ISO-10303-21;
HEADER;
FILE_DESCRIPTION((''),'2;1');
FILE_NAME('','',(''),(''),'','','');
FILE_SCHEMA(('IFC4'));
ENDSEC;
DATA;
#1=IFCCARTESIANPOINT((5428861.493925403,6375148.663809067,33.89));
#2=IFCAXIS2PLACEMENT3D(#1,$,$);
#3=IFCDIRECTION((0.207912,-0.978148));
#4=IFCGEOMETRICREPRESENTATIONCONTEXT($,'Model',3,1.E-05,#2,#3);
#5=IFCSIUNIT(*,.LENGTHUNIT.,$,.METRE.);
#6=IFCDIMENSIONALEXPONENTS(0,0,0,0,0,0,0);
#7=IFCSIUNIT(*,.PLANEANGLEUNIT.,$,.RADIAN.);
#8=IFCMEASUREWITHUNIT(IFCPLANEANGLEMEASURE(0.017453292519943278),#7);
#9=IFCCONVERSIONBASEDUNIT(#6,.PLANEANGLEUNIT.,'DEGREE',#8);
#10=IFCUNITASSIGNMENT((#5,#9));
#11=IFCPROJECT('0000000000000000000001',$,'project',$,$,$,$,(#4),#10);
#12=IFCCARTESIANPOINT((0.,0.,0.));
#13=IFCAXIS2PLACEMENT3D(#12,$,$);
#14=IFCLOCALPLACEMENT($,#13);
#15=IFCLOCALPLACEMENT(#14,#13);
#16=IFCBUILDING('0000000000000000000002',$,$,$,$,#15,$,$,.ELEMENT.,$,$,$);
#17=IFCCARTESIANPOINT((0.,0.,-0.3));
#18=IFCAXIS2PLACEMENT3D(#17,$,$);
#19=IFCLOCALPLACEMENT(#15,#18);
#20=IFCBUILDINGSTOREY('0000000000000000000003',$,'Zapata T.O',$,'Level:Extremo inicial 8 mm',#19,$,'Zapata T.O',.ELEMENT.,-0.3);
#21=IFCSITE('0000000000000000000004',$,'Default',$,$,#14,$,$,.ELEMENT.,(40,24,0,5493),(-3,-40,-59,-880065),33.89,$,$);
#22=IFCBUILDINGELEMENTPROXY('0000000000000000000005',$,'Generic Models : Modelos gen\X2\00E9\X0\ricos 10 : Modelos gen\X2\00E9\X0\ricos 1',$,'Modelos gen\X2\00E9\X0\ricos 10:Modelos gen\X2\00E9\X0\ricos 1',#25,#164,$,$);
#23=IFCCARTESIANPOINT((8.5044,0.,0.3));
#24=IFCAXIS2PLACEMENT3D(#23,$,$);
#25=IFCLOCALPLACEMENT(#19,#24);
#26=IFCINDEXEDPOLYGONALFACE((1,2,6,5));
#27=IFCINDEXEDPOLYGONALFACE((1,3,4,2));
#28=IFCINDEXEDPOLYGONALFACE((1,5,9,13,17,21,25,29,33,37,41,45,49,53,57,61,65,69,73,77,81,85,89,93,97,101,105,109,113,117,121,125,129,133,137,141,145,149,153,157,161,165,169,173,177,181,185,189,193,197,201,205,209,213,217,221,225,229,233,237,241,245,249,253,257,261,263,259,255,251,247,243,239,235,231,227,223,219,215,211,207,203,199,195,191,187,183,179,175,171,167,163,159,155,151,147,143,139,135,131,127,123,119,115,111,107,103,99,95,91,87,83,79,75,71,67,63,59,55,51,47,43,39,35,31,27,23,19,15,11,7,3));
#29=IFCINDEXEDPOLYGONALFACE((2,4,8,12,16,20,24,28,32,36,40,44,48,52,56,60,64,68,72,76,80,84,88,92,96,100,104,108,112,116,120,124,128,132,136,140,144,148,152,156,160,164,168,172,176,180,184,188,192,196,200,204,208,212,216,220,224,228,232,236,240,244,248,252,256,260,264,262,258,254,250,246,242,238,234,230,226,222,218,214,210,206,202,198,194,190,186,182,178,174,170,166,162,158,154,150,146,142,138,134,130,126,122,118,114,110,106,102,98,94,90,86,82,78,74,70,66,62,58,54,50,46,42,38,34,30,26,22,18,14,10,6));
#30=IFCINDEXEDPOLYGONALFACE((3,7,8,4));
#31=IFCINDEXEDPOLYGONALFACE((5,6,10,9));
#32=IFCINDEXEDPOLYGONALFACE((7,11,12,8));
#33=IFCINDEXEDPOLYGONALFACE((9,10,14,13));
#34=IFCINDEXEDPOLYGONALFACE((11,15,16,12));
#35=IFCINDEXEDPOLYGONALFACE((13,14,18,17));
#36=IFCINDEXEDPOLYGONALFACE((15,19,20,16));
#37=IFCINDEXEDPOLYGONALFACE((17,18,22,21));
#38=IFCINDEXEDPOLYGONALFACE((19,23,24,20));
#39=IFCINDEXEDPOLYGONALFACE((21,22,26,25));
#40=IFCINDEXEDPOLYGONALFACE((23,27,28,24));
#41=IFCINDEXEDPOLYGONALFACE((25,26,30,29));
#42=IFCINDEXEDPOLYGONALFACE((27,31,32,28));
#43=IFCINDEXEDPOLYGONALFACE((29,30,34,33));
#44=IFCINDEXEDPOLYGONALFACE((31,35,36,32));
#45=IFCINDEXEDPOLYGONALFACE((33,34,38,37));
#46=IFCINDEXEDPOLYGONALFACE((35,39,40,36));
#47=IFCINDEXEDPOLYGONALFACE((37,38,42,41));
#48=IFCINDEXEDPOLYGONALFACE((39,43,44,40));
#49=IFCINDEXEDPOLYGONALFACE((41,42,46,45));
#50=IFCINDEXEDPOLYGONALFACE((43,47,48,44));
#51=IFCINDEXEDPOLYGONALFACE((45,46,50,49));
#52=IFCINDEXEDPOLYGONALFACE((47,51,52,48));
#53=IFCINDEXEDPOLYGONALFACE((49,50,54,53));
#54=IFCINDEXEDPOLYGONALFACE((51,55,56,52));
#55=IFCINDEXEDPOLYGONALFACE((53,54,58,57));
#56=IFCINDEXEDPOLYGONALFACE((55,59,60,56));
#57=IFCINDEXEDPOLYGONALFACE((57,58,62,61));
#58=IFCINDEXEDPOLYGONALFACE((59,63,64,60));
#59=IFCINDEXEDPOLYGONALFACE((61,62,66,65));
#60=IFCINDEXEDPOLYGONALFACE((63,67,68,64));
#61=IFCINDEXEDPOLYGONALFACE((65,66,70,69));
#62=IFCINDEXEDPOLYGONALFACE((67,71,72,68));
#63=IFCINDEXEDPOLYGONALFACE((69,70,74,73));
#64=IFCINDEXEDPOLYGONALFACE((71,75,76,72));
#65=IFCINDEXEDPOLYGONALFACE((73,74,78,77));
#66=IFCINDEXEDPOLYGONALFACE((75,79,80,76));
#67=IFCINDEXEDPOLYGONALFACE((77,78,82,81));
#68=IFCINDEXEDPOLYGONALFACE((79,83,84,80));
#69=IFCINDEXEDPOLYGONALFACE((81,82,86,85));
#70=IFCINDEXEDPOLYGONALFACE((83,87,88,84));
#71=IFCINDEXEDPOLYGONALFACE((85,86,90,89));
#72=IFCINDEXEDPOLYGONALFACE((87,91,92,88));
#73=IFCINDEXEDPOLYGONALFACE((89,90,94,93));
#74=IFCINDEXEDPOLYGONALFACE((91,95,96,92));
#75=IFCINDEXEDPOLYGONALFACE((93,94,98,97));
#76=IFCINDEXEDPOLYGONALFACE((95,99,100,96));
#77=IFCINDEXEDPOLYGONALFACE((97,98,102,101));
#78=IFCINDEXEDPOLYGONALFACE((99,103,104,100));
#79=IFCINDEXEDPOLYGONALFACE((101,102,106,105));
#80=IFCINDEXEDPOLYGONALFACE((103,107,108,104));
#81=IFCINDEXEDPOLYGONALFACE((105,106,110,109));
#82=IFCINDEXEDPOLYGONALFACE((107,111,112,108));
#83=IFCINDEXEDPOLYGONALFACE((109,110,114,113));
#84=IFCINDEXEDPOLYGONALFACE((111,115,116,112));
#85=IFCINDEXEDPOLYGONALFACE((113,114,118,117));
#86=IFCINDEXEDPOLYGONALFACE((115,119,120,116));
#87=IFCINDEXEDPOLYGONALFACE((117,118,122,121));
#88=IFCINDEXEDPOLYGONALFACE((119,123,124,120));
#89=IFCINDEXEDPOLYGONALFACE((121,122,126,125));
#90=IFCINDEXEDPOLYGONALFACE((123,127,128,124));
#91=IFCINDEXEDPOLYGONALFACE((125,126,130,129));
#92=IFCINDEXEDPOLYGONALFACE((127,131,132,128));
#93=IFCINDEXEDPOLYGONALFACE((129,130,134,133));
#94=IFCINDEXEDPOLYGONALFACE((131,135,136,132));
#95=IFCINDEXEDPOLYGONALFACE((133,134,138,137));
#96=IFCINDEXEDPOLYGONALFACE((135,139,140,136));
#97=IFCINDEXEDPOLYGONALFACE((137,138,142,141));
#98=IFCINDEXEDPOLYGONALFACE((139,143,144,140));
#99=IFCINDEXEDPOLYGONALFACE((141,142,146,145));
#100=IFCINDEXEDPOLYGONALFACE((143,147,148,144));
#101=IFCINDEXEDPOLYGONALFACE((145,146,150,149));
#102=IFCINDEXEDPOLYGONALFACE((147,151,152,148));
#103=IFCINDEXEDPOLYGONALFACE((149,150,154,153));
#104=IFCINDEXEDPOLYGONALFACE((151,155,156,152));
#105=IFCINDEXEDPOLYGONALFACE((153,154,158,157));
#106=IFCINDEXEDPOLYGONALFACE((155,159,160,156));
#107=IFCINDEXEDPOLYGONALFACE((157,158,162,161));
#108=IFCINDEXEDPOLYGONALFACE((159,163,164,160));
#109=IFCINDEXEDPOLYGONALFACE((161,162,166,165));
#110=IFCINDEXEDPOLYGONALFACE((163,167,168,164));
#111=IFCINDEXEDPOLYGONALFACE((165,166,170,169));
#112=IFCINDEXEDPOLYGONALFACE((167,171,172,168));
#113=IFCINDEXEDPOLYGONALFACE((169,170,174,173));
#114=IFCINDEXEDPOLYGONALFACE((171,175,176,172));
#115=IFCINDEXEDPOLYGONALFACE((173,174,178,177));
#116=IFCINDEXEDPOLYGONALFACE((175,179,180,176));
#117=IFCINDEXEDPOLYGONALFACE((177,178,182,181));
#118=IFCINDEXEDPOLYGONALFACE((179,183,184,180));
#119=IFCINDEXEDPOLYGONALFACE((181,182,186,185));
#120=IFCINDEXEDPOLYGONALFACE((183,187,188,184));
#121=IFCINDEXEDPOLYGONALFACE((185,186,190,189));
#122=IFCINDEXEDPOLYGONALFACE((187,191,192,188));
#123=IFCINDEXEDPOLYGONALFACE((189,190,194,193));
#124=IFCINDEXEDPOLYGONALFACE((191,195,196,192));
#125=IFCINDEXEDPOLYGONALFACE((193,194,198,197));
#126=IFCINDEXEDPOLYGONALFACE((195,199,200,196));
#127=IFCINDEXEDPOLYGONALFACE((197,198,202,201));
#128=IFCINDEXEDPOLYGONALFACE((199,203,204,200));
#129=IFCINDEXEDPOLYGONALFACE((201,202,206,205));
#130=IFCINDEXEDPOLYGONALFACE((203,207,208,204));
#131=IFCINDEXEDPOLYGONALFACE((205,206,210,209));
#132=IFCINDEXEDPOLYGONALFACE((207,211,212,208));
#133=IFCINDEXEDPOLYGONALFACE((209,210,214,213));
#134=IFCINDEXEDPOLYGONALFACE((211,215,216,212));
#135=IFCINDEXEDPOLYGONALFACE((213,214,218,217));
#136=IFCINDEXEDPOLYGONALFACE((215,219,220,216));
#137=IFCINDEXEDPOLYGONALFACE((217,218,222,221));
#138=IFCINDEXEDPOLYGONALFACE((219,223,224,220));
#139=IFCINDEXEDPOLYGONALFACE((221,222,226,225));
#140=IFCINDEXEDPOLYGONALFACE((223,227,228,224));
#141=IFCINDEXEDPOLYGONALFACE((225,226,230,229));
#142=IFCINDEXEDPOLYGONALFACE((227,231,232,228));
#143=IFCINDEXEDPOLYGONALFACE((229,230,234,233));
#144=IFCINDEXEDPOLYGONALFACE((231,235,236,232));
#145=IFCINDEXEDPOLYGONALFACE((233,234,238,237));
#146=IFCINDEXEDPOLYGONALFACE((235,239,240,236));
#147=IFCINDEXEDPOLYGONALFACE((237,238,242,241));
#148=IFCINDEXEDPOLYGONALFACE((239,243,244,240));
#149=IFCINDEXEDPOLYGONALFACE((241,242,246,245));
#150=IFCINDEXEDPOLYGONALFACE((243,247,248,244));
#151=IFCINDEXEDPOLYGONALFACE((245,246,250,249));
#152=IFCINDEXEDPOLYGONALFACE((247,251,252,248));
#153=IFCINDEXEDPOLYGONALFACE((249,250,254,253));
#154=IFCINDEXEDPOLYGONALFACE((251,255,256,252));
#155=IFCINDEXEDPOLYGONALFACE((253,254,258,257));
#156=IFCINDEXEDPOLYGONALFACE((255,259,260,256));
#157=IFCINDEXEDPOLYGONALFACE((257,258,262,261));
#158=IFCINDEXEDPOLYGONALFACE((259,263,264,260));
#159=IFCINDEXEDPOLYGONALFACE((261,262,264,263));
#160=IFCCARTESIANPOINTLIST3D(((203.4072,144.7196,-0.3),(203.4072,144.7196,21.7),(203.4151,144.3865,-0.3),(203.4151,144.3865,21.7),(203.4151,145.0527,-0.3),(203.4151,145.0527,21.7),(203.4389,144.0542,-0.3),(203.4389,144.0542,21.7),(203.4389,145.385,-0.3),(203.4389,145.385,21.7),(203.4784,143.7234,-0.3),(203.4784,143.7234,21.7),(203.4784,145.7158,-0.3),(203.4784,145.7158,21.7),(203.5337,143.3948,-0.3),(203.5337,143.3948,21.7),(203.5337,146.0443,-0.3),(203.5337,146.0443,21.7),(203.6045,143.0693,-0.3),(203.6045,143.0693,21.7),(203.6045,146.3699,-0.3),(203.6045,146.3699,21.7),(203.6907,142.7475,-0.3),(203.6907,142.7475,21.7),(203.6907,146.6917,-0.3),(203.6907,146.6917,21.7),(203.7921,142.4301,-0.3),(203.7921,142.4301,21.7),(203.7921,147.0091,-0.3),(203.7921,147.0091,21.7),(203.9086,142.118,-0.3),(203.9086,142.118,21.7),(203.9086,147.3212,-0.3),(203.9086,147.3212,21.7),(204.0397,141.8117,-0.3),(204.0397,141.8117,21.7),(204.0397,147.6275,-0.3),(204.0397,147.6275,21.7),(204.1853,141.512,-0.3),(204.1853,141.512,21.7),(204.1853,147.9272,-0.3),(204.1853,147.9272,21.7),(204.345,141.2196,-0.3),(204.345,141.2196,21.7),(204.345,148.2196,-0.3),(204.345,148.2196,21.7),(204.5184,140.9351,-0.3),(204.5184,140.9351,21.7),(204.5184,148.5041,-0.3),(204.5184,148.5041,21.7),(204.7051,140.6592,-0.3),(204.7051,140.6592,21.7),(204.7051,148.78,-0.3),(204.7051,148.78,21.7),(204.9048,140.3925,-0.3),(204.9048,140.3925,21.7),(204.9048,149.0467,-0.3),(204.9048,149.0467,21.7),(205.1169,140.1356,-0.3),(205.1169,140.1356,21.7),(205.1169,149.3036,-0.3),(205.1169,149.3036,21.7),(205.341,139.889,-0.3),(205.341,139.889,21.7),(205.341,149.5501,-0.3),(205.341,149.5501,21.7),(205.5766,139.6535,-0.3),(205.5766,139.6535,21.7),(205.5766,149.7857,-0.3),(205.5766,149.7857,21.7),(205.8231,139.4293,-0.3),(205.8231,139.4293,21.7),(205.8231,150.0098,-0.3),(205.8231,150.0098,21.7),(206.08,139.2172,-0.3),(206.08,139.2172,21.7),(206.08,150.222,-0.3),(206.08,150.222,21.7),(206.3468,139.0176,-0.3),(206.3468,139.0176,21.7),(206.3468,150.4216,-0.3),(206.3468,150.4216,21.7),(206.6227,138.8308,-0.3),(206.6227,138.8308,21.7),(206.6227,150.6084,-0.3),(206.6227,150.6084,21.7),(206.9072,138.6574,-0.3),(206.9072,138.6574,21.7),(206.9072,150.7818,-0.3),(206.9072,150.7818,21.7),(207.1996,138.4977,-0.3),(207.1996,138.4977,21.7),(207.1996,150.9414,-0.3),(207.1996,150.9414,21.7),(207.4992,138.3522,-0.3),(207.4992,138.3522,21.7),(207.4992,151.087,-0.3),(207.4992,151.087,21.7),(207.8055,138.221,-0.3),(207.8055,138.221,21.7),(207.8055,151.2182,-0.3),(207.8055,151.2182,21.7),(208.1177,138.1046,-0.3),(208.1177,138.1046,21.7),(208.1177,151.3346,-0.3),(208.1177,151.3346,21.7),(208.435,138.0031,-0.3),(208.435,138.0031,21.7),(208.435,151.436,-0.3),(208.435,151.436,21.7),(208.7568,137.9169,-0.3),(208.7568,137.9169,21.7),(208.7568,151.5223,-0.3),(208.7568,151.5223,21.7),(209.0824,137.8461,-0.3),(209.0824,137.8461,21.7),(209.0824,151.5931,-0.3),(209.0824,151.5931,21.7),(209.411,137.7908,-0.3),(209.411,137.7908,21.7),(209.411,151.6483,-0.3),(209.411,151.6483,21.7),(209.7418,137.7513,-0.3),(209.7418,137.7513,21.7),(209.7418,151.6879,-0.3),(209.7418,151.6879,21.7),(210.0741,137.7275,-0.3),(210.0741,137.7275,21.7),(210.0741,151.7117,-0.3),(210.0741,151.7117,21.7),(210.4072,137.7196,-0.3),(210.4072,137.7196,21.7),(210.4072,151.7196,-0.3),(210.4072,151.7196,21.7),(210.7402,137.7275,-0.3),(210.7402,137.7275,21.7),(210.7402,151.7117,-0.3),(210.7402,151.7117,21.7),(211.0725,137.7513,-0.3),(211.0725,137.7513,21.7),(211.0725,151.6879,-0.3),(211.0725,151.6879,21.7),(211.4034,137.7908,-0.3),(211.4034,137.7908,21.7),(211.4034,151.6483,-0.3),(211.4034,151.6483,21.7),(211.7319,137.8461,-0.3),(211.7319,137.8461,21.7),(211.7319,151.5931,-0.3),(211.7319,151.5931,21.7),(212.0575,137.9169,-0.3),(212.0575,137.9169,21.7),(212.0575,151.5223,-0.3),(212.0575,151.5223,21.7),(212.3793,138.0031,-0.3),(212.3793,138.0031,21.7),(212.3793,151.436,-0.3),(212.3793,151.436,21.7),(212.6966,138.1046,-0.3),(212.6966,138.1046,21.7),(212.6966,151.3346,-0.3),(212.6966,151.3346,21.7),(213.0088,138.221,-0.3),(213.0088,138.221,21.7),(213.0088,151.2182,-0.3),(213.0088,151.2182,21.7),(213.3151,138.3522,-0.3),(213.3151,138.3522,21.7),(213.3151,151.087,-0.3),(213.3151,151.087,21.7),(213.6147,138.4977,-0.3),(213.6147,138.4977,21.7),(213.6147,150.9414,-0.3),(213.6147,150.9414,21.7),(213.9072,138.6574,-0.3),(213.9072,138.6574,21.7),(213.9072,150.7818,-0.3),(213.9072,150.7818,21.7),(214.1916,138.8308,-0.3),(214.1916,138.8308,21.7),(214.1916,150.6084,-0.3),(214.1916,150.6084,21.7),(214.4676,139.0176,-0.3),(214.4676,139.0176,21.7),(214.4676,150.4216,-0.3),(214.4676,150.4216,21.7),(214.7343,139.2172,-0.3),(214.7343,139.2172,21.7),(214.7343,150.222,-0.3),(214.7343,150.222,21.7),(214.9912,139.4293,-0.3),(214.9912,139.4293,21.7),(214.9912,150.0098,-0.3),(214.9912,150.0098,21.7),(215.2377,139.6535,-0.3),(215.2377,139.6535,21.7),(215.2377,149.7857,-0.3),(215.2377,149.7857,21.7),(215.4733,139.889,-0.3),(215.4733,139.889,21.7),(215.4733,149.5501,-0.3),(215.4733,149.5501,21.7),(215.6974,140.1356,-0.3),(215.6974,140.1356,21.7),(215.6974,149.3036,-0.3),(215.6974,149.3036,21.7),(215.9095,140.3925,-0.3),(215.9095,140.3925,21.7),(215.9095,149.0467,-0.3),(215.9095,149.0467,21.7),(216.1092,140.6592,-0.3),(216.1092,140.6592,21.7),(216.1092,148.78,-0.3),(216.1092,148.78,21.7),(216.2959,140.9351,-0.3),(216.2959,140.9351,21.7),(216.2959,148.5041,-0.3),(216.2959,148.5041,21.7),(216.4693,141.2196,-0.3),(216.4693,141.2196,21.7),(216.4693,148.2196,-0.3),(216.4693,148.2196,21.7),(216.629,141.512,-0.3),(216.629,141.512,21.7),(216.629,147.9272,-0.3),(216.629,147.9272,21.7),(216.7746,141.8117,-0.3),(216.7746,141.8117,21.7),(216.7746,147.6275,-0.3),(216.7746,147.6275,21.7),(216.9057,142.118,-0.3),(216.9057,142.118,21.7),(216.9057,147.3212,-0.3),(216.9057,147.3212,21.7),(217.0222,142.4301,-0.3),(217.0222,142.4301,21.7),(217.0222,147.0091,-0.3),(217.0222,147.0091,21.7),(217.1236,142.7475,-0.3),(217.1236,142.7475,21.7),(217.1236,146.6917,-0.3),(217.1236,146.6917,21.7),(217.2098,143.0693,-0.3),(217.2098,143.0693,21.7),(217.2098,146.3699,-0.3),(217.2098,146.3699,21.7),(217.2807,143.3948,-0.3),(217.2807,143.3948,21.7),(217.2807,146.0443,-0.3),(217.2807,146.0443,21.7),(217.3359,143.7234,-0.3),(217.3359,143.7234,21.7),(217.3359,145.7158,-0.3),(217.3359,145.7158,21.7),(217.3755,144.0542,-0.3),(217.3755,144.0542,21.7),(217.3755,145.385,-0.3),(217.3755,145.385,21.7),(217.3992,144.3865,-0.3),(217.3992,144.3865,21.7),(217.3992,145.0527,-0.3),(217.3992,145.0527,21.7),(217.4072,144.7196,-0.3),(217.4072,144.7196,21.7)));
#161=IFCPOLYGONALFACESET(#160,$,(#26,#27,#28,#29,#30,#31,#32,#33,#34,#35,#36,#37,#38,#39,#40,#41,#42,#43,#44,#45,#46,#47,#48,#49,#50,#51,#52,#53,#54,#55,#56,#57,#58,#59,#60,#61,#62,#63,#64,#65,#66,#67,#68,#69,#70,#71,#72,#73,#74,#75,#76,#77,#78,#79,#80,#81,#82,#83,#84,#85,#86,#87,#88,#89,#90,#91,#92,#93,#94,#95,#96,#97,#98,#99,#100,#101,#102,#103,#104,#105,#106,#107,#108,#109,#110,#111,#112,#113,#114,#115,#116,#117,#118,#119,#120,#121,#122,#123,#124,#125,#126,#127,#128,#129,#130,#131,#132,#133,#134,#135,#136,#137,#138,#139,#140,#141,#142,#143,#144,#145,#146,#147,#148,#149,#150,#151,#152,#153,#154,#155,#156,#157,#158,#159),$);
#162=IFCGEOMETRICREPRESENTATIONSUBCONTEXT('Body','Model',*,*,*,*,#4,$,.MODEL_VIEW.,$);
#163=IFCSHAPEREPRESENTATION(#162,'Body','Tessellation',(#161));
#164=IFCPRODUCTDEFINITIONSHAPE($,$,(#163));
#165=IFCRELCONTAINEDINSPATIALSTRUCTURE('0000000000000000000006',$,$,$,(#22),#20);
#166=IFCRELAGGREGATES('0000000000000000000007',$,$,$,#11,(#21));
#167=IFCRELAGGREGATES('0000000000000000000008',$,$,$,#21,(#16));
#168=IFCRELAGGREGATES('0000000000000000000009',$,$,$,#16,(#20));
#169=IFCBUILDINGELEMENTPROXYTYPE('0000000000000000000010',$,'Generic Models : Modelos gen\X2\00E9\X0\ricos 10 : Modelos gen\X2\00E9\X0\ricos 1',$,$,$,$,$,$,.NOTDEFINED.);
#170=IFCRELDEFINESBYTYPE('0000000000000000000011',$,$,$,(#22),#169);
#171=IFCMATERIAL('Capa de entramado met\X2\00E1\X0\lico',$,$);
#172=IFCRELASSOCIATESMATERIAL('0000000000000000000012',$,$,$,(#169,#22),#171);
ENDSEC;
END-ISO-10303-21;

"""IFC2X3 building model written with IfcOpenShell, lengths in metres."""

from ifc_helpers import new_model, entity, si_unit, converted_unit, direction, frame, frame_2d, origin, place, context, subcontext, project, spatial, circle, extrude, source, transform, mapped, material, type_object, type_shapes, element, save


model = new_model("IFC2X3")

# Units and contexts
model_context = context("Model", 3, precision=1e-05, world=frame((5428861.493925403, 6375148.663809067, 33.89)), true_north=direction((0.207912, -0.978148)))
body_context = subcontext(model_context, "Body", "Model", "MODEL_VIEW")
ifc_project = project(units=[si_unit("LENGTHUNIT", "METRE"), converted_unit("PLANEANGLEUNIT", "DEGREE", entity("IfcPlaneAngleMeasure", 0.017453292519943278), si_unit("PLANEANGLEUNIT", "RADIAN"), dimensions=[0, 0, 0, 0, 0, 0, 0])], contexts=[model_context])

# Site, building, storey
site_placement = place(None, origin())
site = spatial("IfcSite", under=ifc_project, at=site_placement, Name="Default", CompositionType="ELEMENT", RefLatitude=(40, 24, 0, 5493), RefLongitude=(-3, -40, -59, -880065), RefElevation=33.89)
building_placement = place(site_placement, origin())
building = spatial("IfcBuilding", under=site, at=building_placement, CompositionType="ELEMENT")
storey_placement = place(building_placement, frame((0.0, 0.0, -0.3)))
storey = spatial("IfcBuildingStorey", under=building, at=storey_placement, Name="Zapata T.O", ObjectType="Level:Extremo inicial 8 mm", LongName="Zapata T.O", CompositionType="ELEMENT", Elevation=-0.3)

# Building element proxy
ifc_material = material(Name="Capa de entramado metálico")
building_element_proxy_type_1 = type_object("IfcBuildingElementProxyType", Name="Generic Models : Modelos genéricos 10 : Modelos genéricos 1", PredefinedType="NOTDEFINED", material=ifc_material)
shared_shape_1 = source(origin(), body_context, "Body", "SweptSolid", [
    extrude(circle(Radius=7.0, at=frame_2d((0.0, 0.0), x_axis=(1.0, 0.0))), frame((210.4072, 144.7196, -0.3)), (0.0, 0.0, 1.0), 22.0),
])
type_shapes(building_element_proxy_type_1, [shared_shape_1])
proxy_1_placement = place(storey_placement, frame((8.5044, 0.0, 0.3)))
element("IfcBuildingElementProxy", 1, at=proxy_1_placement, inside=storey, type_object=building_element_proxy_type_1, material=ifc_material, Name="Generic Models : Modelos genéricos 10 : Modelos genéricos 1", ObjectType="Modelos genéricos 10:Modelos genéricos 1", context=body_context, shape_type="MappedRepresentation", body=[
    mapped(shared_shape_1, transform((0.0, 0.0, 0.0), scale=1.0)),
])

save(model, "model.ifc")
